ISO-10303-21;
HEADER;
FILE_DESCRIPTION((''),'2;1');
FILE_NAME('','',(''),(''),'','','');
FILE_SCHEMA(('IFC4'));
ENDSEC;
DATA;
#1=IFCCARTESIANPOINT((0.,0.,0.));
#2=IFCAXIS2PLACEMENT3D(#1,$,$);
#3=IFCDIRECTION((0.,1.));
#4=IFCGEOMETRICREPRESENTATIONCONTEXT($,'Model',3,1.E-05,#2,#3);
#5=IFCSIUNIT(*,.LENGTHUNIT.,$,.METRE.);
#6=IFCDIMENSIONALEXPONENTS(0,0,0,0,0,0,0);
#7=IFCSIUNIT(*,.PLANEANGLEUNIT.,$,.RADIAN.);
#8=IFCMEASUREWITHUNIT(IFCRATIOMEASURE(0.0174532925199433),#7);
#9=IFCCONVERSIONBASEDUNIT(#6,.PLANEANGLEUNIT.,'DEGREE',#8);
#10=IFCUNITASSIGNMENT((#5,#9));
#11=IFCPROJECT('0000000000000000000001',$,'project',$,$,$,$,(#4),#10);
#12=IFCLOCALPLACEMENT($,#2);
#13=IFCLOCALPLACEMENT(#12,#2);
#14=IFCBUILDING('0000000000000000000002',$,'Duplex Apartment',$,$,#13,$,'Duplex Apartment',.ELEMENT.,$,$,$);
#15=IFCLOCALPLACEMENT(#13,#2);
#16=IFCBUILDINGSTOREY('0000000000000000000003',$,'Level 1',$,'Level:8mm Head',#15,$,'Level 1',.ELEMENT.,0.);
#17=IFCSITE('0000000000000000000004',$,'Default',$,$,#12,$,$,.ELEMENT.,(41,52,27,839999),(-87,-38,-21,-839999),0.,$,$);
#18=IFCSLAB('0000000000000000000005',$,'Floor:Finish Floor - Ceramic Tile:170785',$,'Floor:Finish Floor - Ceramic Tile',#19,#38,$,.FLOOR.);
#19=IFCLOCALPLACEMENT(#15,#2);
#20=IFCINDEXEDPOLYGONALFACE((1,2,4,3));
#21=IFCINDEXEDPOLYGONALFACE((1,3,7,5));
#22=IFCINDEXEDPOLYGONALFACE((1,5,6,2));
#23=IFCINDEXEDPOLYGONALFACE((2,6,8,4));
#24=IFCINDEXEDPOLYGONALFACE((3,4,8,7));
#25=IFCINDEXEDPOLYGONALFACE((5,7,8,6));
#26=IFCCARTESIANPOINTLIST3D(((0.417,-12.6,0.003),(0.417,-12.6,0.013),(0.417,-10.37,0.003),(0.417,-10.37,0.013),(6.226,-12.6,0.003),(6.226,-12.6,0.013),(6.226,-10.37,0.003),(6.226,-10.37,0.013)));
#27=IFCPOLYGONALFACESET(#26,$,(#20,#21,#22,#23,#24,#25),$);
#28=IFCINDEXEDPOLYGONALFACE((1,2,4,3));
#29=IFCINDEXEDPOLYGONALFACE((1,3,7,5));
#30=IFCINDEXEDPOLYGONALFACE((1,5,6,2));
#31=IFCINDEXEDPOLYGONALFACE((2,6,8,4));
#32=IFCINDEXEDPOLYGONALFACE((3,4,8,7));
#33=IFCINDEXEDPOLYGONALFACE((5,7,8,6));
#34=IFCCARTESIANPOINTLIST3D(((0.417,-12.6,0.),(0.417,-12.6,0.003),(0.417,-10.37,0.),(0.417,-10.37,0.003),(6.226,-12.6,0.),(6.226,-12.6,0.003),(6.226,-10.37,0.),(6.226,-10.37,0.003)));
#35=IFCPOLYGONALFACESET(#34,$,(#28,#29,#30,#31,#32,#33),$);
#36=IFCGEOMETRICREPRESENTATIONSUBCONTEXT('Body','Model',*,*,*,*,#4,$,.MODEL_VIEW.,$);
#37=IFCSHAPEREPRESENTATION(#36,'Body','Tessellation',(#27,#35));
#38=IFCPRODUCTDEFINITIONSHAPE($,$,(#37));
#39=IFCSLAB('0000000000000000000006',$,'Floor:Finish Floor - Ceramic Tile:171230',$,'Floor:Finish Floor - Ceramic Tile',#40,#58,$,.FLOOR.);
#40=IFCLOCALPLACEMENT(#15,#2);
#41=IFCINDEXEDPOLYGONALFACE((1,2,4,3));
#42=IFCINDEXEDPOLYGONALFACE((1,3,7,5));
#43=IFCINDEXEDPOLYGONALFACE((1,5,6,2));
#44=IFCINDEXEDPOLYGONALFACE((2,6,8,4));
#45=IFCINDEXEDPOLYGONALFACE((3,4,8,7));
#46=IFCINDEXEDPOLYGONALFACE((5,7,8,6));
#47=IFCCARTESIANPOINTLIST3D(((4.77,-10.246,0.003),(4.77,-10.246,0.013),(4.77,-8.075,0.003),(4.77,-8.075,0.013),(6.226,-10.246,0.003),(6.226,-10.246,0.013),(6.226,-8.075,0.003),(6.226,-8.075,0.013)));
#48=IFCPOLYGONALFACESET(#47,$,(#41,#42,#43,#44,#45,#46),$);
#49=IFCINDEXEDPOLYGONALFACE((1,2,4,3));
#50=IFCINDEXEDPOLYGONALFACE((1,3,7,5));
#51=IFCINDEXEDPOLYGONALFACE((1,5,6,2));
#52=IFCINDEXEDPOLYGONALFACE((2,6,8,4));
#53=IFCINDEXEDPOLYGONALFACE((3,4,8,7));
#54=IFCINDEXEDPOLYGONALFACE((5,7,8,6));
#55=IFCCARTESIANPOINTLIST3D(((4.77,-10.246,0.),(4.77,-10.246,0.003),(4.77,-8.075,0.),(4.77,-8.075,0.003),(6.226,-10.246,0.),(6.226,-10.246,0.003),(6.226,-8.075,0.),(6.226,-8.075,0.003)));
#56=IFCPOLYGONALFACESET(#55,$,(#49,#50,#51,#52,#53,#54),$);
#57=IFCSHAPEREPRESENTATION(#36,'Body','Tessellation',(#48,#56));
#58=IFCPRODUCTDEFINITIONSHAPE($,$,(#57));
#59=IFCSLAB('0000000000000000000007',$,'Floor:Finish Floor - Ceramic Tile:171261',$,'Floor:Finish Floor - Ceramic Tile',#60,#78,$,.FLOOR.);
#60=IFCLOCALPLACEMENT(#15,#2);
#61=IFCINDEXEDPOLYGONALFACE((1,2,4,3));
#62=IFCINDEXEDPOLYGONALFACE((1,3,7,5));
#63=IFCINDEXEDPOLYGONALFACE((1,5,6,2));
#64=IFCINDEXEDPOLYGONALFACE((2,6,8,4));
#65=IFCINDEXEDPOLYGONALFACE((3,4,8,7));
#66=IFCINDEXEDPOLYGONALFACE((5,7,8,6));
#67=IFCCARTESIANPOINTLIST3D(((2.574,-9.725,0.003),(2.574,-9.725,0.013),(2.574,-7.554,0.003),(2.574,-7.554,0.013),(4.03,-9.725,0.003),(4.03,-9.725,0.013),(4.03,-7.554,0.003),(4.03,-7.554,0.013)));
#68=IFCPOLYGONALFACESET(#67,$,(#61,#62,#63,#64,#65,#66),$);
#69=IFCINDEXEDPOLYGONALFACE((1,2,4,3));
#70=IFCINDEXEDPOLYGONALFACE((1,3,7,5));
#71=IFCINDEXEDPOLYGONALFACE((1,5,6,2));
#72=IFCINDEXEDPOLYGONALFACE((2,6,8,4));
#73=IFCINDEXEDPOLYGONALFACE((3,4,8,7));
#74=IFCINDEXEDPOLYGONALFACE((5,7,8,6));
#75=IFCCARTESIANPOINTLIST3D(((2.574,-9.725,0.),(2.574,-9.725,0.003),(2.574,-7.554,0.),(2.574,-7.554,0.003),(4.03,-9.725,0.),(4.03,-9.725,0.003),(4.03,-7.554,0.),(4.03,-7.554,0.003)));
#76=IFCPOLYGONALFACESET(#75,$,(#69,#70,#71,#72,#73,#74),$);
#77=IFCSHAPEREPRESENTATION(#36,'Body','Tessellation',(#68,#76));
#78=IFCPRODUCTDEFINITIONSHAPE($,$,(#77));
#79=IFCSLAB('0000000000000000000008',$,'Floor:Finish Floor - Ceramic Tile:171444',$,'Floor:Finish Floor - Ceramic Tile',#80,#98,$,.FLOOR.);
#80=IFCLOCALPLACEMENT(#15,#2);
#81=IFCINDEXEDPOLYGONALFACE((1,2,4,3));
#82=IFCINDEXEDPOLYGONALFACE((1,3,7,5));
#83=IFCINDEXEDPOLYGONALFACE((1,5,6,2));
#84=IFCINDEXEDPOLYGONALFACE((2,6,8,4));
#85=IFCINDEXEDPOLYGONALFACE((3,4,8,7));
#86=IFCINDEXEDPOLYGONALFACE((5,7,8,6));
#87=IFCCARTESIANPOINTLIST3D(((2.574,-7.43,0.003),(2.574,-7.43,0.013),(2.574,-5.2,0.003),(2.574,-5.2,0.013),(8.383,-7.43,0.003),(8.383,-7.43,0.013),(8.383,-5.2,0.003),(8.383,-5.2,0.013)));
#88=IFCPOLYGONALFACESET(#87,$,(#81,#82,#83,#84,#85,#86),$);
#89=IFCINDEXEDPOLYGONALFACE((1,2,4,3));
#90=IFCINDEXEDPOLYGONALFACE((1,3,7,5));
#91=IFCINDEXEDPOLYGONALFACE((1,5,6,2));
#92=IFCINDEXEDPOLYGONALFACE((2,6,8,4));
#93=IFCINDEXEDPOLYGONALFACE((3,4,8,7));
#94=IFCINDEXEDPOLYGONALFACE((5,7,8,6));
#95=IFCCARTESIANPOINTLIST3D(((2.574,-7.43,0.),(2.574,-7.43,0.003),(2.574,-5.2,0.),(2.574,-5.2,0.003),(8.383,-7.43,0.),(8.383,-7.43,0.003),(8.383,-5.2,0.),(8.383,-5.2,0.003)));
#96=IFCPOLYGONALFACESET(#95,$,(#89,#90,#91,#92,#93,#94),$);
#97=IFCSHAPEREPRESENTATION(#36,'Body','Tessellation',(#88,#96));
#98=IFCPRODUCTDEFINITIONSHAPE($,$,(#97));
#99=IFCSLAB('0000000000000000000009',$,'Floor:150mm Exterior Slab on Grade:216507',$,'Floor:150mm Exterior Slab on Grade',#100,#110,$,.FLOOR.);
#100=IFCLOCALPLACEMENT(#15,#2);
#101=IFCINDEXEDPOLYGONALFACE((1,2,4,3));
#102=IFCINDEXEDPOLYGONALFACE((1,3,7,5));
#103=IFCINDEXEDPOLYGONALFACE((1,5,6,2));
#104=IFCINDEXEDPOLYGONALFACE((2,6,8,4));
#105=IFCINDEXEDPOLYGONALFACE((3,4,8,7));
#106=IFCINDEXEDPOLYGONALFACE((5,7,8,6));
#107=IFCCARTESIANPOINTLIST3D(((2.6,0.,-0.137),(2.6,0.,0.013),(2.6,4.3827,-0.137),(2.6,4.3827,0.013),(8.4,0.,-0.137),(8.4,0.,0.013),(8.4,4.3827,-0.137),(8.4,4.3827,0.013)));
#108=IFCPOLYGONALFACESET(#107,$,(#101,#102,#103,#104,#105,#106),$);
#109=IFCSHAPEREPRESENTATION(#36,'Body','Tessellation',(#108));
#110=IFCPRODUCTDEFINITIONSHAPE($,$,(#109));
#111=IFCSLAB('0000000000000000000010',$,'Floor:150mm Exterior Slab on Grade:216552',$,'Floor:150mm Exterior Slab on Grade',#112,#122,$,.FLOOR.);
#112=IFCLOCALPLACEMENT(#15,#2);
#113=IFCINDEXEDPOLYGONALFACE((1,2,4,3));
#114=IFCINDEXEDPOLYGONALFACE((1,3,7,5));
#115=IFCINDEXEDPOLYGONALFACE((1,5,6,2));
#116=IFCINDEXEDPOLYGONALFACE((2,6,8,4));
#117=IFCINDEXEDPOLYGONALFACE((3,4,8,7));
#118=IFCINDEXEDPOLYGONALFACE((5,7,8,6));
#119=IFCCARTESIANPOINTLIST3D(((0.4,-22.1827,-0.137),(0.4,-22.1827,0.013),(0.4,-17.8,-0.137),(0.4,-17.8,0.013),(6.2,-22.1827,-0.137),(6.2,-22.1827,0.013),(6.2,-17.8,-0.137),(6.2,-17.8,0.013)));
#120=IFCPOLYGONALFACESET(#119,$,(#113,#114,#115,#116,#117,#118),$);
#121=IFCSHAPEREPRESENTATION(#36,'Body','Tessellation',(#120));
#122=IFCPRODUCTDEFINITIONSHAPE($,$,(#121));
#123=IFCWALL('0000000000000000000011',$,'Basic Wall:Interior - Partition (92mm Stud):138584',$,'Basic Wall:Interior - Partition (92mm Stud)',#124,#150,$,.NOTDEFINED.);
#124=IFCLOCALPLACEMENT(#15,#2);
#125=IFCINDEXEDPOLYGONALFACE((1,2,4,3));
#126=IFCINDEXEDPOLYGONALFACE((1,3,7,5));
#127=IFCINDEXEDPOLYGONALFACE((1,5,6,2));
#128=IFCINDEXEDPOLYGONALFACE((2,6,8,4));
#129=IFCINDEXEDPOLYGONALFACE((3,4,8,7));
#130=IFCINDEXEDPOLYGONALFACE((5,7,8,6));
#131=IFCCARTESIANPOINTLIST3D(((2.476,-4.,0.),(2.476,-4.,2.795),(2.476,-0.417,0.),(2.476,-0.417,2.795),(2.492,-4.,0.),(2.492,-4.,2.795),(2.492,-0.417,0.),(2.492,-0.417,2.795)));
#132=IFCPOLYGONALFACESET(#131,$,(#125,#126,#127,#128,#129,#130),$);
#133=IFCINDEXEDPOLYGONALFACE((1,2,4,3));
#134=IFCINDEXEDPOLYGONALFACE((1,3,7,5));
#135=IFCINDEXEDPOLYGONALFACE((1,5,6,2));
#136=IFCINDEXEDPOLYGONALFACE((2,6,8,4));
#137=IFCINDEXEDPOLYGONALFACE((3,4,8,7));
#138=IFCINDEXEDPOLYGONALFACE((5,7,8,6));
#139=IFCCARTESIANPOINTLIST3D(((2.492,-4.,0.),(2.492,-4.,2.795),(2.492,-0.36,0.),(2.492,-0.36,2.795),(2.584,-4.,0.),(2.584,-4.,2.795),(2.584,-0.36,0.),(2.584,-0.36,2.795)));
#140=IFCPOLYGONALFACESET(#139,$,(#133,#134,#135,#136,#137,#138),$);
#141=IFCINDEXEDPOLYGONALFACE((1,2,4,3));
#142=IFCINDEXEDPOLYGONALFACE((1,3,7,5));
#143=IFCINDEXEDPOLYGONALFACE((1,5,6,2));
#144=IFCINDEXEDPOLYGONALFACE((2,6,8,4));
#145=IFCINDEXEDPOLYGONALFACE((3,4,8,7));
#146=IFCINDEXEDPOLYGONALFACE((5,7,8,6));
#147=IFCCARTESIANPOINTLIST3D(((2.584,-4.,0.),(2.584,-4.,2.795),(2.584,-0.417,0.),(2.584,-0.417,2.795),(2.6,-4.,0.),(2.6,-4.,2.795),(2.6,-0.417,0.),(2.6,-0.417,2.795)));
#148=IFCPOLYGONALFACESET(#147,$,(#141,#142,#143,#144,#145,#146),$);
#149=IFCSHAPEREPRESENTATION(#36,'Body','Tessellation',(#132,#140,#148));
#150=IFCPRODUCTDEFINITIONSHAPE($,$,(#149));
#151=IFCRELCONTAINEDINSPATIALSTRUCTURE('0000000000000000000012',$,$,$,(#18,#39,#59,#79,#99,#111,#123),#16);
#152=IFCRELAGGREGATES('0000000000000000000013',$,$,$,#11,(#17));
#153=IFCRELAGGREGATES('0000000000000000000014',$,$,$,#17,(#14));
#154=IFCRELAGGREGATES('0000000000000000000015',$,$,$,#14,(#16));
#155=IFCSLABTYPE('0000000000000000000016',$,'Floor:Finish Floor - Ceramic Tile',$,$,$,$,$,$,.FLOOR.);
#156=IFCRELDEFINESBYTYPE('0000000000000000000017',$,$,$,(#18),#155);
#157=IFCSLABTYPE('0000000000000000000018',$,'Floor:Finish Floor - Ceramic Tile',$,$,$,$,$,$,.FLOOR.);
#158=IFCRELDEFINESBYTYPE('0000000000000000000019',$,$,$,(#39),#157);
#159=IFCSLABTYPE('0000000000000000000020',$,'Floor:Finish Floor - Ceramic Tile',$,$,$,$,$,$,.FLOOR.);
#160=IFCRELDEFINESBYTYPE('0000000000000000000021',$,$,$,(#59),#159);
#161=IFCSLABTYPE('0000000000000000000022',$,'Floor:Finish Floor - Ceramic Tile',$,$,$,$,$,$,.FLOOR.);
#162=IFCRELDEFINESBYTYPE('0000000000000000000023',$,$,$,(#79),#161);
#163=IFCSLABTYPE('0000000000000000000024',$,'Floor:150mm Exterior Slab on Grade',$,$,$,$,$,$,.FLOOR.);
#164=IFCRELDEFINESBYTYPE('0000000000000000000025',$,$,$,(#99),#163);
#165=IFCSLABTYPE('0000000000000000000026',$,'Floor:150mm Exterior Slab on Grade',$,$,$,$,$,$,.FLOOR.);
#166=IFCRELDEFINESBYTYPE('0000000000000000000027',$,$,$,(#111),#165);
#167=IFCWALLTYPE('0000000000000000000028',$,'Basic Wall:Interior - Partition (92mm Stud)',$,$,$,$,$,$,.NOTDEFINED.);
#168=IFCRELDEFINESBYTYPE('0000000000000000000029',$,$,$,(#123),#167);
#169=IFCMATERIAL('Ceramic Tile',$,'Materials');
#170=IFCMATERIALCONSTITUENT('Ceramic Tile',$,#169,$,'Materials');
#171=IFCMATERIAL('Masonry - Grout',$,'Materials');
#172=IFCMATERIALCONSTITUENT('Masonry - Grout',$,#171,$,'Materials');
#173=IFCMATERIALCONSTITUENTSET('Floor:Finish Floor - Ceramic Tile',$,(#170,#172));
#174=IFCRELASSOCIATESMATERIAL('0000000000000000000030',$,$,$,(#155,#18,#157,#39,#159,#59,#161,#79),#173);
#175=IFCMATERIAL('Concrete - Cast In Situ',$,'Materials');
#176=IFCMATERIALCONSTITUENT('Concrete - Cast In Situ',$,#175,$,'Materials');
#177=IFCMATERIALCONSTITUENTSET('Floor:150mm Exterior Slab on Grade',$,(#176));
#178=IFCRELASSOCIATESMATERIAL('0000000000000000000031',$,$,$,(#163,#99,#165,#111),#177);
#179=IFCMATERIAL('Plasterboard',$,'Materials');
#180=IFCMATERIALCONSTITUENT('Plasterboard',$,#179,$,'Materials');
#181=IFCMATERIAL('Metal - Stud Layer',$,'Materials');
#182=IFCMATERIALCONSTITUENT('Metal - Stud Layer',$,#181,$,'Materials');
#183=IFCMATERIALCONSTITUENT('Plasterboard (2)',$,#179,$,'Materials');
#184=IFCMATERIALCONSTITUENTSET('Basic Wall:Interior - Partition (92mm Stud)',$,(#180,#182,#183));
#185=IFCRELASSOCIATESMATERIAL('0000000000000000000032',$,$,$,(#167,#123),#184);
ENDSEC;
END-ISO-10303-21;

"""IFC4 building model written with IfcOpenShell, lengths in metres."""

from ifc_helpers import new_model, entity, si_unit, converted_unit, direction, frame, origin, place, context, subcontext, project, spatial, indexed_curve, outline, extrude, material, constituent, constituent_set, type_object, element, save


model = new_model("IFC4")

# Units and contexts
model_context = context("Model", 3, precision=1e-05, world=origin(), true_north=direction((0.0, 1.0)))
body_context = subcontext(model_context, "Body", "Model", "MODEL_VIEW")
ifc_project = project(units=[si_unit("LENGTHUNIT", "METRE"), converted_unit("PLANEANGLEUNIT", "DEGREE", entity("IfcRatioMeasure", 0.0174532925199433), si_unit("PLANEANGLEUNIT", "RADIAN"), dimensions=[0, 0, 0, 0, 0, 0, 0])], contexts=[model_context])

# Site, building, storey
site_placement = place(None, origin())
site = spatial("IfcSite", under=ifc_project, at=site_placement, Name="Default", CompositionType="ELEMENT", RefLatitude=(41, 52, 27, 839999), RefLongitude=(-87, -38, -21, -839999), RefElevation=0.0)
building_placement = place(site_placement, origin())
building = spatial("IfcBuilding", under=site, at=building_placement, Name="Duplex Apartment", LongName="Duplex Apartment", CompositionType="ELEMENT")
storey_placement = place(building_placement, origin())
storey = spatial("IfcBuildingStorey", under=building, at=storey_placement, Name="Level 1", ObjectType="Level:8mm Head", LongName="Level 1", CompositionType="ELEMENT", Elevation=0.0)

# Slabs
ifc_material_1 = material(Name="Ceramic Tile", Category="Materials")
ifc_constituent_1 = constituent(ifc_material_1, Name="Ceramic Tile", Category="Materials")
ifc_material_2 = material(Name="Masonry - Grout", Category="Materials")
ifc_constituent_2 = constituent(ifc_material_2, Name="Masonry - Grout", Category="Materials")
ifc_constituent_set_1 = constituent_set(constituents=[ifc_constituent_1, ifc_constituent_2], Name="Floor:Finish Floor - Ceramic Tile")
slab_type_1 = type_object("IfcSlabType", Name="Floor:Finish Floor - Ceramic Tile", PredefinedType="FLOOR", material=ifc_constituent_set_1)
slab_1_placement = place(storey_placement, origin())
element("IfcSlab", 1, at=slab_1_placement, inside=storey, type_object=slab_type_1, material=ifc_constituent_set_1, Name="Floor:Finish Floor - Ceramic Tile:170785", ObjectType="Floor:Finish Floor - Ceramic Tile", PredefinedType="FLOOR", context=body_context, shape_type="SweptSolid", body=[
    extrude(outline(indexed_curve([(-1.115, -2.9045), (1.115, -2.9045), (1.115, 2.9045), (-1.115, 2.9045), (-1.115, -2.9045)], self_intersect=False)), frame((3.3215, -11.485, 0.003), z_axis=(0.0, 0.0, 1.0), x_axis=(0.0, -1.0, 0.0)), (0.0, 0.0, 1.0), 0.01),
    extrude(outline(indexed_curve([(-1.115, -2.9045), (1.115, -2.9045), (1.115, 2.9045), (-1.115, 2.9045), (-1.115, -2.9045)], self_intersect=False)), frame((3.3215, -11.485, 0.0), z_axis=(0.0, 0.0, 1.0), x_axis=(0.0, -1.0, 0.0)), (0.0, 0.0, 1.0), 0.003),
])
slab_type_2 = type_object("IfcSlabType", Name="Floor:Finish Floor - Ceramic Tile", PredefinedType="FLOOR", material=ifc_constituent_set_1)
slab_2_placement = place(storey_placement, origin())
element("IfcSlab", 2, at=slab_2_placement, inside=storey, type_object=slab_type_2, material=ifc_constituent_set_1, Name="Floor:Finish Floor - Ceramic Tile:171230", ObjectType="Floor:Finish Floor - Ceramic Tile", PredefinedType="FLOOR", context=body_context, shape_type="SweptSolid", body=[
    extrude(outline(indexed_curve([(-1.0855, -0.728), (1.0855, -0.728), (1.0855, 0.728), (-1.0855, 0.728), (-1.0855, -0.728)], self_intersect=False)), frame((5.498, -9.1605, 0.003), z_axis=(0.0, 0.0, 1.0), x_axis=(0.0, -1.0, 0.0)), (0.0, 0.0, 1.0), 0.01),
    extrude(outline(indexed_curve([(-1.0855, -0.728), (1.0855, -0.728), (1.0855, 0.728), (-1.0855, 0.728), (-1.0855, -0.728)], self_intersect=False)), frame((5.498, -9.1605, 0.0), z_axis=(0.0, 0.0, 1.0), x_axis=(0.0, -1.0, 0.0)), (0.0, 0.0, 1.0), 0.003),
])
slab_type_3 = type_object("IfcSlabType", Name="Floor:Finish Floor - Ceramic Tile", PredefinedType="FLOOR", material=ifc_constituent_set_1)
slab_3_placement = place(storey_placement, origin())
element("IfcSlab", 3, at=slab_3_placement, inside=storey, type_object=slab_type_3, material=ifc_constituent_set_1, Name="Floor:Finish Floor - Ceramic Tile:171261", ObjectType="Floor:Finish Floor - Ceramic Tile", PredefinedType="FLOOR", context=body_context, shape_type="SweptSolid", body=[
    extrude(outline(indexed_curve([(-0.728, -1.0855), (0.728, -1.0855), (0.728, 1.0855), (-0.728, 1.0855), (-0.728, -1.0855)], self_intersect=False)), frame((3.302, -8.6395, 0.003), z_axis=(0.0, 0.0, 1.0), x_axis=(-1.0, 0.0, 0.0)), (0.0, 0.0, 1.0), 0.01),
    extrude(outline(indexed_curve([(-0.728, -1.0855), (0.728, -1.0855), (0.728, 1.0855), (-0.728, 1.0855), (-0.728, -1.0855)], self_intersect=False)), frame((3.302, -8.6395, 0.0), z_axis=(0.0, 0.0, 1.0), x_axis=(-1.0, 0.0, 0.0)), (0.0, 0.0, 1.0), 0.003),
])
slab_type_4 = type_object("IfcSlabType", Name="Floor:Finish Floor - Ceramic Tile", PredefinedType="FLOOR", material=ifc_constituent_set_1)
slab_4_placement = place(storey_placement, origin())
element("IfcSlab", 4, at=slab_4_placement, inside=storey, type_object=slab_type_4, material=ifc_constituent_set_1, Name="Floor:Finish Floor - Ceramic Tile:171444", ObjectType="Floor:Finish Floor - Ceramic Tile", PredefinedType="FLOOR", context=body_context, shape_type="SweptSolid", body=[
    extrude(outline(indexed_curve([(-1.115, -2.9045), (1.115, -2.9045), (1.115, 2.9045), (-1.115, 2.9045), (-1.115, -2.9045)], self_intersect=False)), frame((5.4785, -6.315, 0.003), z_axis=(0.0, 0.0, 1.0), x_axis=(0.0, -1.0, 0.0)), (0.0, 0.0, 1.0), 0.01),
    extrude(outline(indexed_curve([(-1.115, -2.9045), (1.115, -2.9045), (1.115, 2.9045), (-1.115, 2.9045), (-1.115, -2.9045)], self_intersect=False)), frame((5.4785, -6.315, 0.0), z_axis=(0.0, 0.0, 1.0), x_axis=(0.0, -1.0, 0.0)), (0.0, 0.0, 1.0), 0.003),
])
ifc_material_3 = material(Name="Concrete - Cast In Situ", Category="Materials")
ifc_constituent_3 = constituent(ifc_material_3, Name="Concrete - Cast In Situ", Category="Materials")
ifc_constituent_set_2 = constituent_set(constituents=[ifc_constituent_3], Name="Floor:150mm Exterior Slab on Grade")
slab_type_5 = type_object("IfcSlabType", Name="Floor:150mm Exterior Slab on Grade", PredefinedType="FLOOR", material=ifc_constituent_set_2)
slab_5_placement = place(storey_placement, origin())
element("IfcSlab", 5, at=slab_5_placement, inside=storey, type_object=slab_type_5, material=ifc_constituent_set_2, Name="Floor:150mm Exterior Slab on Grade:216507", ObjectType="Floor:150mm Exterior Slab on Grade", PredefinedType="FLOOR", context=body_context, shape_type="SweptSolid", body=[
    extrude(outline(indexed_curve([(-2.1914, -2.9), (2.1914, -2.9), (2.1914, 2.9), (-2.1914, 2.9), (-2.1914, -2.9)], self_intersect=False)), frame((5.5, 2.1914, -0.137), z_axis=(0.0, 0.0, 1.0), x_axis=(0.0, -1.0, 0.0)), (0.0, 0.0, 1.0), 0.15),
])
slab_type_6 = type_object("IfcSlabType", Name="Floor:150mm Exterior Slab on Grade", PredefinedType="FLOOR", material=ifc_constituent_set_2)
slab_6_placement = place(storey_placement, origin())
element("IfcSlab", 6, at=slab_6_placement, inside=storey, type_object=slab_type_6, material=ifc_constituent_set_2, Name="Floor:150mm Exterior Slab on Grade:216552", ObjectType="Floor:150mm Exterior Slab on Grade", PredefinedType="FLOOR", context=body_context, shape_type="SweptSolid", body=[
    extrude(outline(indexed_curve([(-2.1914, -2.9), (2.1914, -2.9), (2.1914, 2.9), (-2.1914, 2.9), (-2.1914, -2.9)], self_intersect=False)), frame((3.3, -19.9914, -0.137), z_axis=(0.0, 0.0, 1.0), x_axis=(0.0, 1.0, 0.0)), (0.0, 0.0, 1.0), 0.15),
])

# Shared definitions
ifc_material_4 = material(Name="Metal - Stud Layer", Category="Materials")
ifc_material_5 = material(Name="Plasterboard", Category="Materials")

# Wall
ifc_constituent_4 = constituent(ifc_material_5, Name="Plasterboard", Category="Materials")
ifc_constituent_5 = constituent(ifc_material_4, Name="Metal - Stud Layer", Category="Materials")
ifc_constituent_6 = constituent(ifc_material_5, Name="Plasterboard (2)", Category="Materials")
ifc_constituent_set_3 = constituent_set(constituents=[ifc_constituent_4, ifc_constituent_5, ifc_constituent_6], Name="Basic Wall:Interior - Partition (92mm Stud)")
wall_type_1 = type_object("IfcWallType", Name="Basic Wall:Interior - Partition (92mm Stud)", PredefinedType="NOTDEFINED", material=ifc_constituent_set_3)
wall_1_placement = place(storey_placement, frame((2.538, -0.417, 0.0), z_axis=(0.0, 0.0, 1.0), x_axis=(0.0, -1.0, 0.0)))
element("IfcWall", 7, at=wall_1_placement, inside=storey, type_object=wall_type_1, material=ifc_constituent_set_3, Name="Basic Wall:Interior - Partition (92mm Stud):138584", ObjectType="Basic Wall:Interior - Partition (92mm Stud)", PredefinedType="NOTDEFINED", context=body_context, shape_type="SweptSolid", body=[
    extrude(outline(indexed_curve([(-0.008, -1.7915), (0.008, -1.7915), (0.008, 1.7915), (-0.008, 1.7915), (-0.008, -1.7915)], self_intersect=False)), frame((1.7915, -0.054, 0.0), z_axis=(0.0, 0.0, 1.0), x_axis=(0.0, 1.0, 0.0)), (0.0, 0.0, 1.0), 2.795),
    extrude(outline(indexed_curve([(-1.82, -0.046), (1.82, -0.046), (1.82, 0.046), (-1.82, 0.046), (-1.82, -0.046)], self_intersect=False)), frame((1.763, 0.0, 0.0)), (0.0, 0.0, 1.0), 2.795),
    extrude(outline(indexed_curve([(-0.008, -1.7915), (0.008, -1.7915), (0.008, 1.7915), (-0.008, 1.7915), (-0.008, -1.7915)], self_intersect=False)), frame((1.7915, 0.054, 0.0), z_axis=(0.0, 0.0, 1.0), x_axis=(0.0, -1.0, 0.0)), (0.0, 0.0, 1.0), 2.795),
])

save(model, "model.ifc")
